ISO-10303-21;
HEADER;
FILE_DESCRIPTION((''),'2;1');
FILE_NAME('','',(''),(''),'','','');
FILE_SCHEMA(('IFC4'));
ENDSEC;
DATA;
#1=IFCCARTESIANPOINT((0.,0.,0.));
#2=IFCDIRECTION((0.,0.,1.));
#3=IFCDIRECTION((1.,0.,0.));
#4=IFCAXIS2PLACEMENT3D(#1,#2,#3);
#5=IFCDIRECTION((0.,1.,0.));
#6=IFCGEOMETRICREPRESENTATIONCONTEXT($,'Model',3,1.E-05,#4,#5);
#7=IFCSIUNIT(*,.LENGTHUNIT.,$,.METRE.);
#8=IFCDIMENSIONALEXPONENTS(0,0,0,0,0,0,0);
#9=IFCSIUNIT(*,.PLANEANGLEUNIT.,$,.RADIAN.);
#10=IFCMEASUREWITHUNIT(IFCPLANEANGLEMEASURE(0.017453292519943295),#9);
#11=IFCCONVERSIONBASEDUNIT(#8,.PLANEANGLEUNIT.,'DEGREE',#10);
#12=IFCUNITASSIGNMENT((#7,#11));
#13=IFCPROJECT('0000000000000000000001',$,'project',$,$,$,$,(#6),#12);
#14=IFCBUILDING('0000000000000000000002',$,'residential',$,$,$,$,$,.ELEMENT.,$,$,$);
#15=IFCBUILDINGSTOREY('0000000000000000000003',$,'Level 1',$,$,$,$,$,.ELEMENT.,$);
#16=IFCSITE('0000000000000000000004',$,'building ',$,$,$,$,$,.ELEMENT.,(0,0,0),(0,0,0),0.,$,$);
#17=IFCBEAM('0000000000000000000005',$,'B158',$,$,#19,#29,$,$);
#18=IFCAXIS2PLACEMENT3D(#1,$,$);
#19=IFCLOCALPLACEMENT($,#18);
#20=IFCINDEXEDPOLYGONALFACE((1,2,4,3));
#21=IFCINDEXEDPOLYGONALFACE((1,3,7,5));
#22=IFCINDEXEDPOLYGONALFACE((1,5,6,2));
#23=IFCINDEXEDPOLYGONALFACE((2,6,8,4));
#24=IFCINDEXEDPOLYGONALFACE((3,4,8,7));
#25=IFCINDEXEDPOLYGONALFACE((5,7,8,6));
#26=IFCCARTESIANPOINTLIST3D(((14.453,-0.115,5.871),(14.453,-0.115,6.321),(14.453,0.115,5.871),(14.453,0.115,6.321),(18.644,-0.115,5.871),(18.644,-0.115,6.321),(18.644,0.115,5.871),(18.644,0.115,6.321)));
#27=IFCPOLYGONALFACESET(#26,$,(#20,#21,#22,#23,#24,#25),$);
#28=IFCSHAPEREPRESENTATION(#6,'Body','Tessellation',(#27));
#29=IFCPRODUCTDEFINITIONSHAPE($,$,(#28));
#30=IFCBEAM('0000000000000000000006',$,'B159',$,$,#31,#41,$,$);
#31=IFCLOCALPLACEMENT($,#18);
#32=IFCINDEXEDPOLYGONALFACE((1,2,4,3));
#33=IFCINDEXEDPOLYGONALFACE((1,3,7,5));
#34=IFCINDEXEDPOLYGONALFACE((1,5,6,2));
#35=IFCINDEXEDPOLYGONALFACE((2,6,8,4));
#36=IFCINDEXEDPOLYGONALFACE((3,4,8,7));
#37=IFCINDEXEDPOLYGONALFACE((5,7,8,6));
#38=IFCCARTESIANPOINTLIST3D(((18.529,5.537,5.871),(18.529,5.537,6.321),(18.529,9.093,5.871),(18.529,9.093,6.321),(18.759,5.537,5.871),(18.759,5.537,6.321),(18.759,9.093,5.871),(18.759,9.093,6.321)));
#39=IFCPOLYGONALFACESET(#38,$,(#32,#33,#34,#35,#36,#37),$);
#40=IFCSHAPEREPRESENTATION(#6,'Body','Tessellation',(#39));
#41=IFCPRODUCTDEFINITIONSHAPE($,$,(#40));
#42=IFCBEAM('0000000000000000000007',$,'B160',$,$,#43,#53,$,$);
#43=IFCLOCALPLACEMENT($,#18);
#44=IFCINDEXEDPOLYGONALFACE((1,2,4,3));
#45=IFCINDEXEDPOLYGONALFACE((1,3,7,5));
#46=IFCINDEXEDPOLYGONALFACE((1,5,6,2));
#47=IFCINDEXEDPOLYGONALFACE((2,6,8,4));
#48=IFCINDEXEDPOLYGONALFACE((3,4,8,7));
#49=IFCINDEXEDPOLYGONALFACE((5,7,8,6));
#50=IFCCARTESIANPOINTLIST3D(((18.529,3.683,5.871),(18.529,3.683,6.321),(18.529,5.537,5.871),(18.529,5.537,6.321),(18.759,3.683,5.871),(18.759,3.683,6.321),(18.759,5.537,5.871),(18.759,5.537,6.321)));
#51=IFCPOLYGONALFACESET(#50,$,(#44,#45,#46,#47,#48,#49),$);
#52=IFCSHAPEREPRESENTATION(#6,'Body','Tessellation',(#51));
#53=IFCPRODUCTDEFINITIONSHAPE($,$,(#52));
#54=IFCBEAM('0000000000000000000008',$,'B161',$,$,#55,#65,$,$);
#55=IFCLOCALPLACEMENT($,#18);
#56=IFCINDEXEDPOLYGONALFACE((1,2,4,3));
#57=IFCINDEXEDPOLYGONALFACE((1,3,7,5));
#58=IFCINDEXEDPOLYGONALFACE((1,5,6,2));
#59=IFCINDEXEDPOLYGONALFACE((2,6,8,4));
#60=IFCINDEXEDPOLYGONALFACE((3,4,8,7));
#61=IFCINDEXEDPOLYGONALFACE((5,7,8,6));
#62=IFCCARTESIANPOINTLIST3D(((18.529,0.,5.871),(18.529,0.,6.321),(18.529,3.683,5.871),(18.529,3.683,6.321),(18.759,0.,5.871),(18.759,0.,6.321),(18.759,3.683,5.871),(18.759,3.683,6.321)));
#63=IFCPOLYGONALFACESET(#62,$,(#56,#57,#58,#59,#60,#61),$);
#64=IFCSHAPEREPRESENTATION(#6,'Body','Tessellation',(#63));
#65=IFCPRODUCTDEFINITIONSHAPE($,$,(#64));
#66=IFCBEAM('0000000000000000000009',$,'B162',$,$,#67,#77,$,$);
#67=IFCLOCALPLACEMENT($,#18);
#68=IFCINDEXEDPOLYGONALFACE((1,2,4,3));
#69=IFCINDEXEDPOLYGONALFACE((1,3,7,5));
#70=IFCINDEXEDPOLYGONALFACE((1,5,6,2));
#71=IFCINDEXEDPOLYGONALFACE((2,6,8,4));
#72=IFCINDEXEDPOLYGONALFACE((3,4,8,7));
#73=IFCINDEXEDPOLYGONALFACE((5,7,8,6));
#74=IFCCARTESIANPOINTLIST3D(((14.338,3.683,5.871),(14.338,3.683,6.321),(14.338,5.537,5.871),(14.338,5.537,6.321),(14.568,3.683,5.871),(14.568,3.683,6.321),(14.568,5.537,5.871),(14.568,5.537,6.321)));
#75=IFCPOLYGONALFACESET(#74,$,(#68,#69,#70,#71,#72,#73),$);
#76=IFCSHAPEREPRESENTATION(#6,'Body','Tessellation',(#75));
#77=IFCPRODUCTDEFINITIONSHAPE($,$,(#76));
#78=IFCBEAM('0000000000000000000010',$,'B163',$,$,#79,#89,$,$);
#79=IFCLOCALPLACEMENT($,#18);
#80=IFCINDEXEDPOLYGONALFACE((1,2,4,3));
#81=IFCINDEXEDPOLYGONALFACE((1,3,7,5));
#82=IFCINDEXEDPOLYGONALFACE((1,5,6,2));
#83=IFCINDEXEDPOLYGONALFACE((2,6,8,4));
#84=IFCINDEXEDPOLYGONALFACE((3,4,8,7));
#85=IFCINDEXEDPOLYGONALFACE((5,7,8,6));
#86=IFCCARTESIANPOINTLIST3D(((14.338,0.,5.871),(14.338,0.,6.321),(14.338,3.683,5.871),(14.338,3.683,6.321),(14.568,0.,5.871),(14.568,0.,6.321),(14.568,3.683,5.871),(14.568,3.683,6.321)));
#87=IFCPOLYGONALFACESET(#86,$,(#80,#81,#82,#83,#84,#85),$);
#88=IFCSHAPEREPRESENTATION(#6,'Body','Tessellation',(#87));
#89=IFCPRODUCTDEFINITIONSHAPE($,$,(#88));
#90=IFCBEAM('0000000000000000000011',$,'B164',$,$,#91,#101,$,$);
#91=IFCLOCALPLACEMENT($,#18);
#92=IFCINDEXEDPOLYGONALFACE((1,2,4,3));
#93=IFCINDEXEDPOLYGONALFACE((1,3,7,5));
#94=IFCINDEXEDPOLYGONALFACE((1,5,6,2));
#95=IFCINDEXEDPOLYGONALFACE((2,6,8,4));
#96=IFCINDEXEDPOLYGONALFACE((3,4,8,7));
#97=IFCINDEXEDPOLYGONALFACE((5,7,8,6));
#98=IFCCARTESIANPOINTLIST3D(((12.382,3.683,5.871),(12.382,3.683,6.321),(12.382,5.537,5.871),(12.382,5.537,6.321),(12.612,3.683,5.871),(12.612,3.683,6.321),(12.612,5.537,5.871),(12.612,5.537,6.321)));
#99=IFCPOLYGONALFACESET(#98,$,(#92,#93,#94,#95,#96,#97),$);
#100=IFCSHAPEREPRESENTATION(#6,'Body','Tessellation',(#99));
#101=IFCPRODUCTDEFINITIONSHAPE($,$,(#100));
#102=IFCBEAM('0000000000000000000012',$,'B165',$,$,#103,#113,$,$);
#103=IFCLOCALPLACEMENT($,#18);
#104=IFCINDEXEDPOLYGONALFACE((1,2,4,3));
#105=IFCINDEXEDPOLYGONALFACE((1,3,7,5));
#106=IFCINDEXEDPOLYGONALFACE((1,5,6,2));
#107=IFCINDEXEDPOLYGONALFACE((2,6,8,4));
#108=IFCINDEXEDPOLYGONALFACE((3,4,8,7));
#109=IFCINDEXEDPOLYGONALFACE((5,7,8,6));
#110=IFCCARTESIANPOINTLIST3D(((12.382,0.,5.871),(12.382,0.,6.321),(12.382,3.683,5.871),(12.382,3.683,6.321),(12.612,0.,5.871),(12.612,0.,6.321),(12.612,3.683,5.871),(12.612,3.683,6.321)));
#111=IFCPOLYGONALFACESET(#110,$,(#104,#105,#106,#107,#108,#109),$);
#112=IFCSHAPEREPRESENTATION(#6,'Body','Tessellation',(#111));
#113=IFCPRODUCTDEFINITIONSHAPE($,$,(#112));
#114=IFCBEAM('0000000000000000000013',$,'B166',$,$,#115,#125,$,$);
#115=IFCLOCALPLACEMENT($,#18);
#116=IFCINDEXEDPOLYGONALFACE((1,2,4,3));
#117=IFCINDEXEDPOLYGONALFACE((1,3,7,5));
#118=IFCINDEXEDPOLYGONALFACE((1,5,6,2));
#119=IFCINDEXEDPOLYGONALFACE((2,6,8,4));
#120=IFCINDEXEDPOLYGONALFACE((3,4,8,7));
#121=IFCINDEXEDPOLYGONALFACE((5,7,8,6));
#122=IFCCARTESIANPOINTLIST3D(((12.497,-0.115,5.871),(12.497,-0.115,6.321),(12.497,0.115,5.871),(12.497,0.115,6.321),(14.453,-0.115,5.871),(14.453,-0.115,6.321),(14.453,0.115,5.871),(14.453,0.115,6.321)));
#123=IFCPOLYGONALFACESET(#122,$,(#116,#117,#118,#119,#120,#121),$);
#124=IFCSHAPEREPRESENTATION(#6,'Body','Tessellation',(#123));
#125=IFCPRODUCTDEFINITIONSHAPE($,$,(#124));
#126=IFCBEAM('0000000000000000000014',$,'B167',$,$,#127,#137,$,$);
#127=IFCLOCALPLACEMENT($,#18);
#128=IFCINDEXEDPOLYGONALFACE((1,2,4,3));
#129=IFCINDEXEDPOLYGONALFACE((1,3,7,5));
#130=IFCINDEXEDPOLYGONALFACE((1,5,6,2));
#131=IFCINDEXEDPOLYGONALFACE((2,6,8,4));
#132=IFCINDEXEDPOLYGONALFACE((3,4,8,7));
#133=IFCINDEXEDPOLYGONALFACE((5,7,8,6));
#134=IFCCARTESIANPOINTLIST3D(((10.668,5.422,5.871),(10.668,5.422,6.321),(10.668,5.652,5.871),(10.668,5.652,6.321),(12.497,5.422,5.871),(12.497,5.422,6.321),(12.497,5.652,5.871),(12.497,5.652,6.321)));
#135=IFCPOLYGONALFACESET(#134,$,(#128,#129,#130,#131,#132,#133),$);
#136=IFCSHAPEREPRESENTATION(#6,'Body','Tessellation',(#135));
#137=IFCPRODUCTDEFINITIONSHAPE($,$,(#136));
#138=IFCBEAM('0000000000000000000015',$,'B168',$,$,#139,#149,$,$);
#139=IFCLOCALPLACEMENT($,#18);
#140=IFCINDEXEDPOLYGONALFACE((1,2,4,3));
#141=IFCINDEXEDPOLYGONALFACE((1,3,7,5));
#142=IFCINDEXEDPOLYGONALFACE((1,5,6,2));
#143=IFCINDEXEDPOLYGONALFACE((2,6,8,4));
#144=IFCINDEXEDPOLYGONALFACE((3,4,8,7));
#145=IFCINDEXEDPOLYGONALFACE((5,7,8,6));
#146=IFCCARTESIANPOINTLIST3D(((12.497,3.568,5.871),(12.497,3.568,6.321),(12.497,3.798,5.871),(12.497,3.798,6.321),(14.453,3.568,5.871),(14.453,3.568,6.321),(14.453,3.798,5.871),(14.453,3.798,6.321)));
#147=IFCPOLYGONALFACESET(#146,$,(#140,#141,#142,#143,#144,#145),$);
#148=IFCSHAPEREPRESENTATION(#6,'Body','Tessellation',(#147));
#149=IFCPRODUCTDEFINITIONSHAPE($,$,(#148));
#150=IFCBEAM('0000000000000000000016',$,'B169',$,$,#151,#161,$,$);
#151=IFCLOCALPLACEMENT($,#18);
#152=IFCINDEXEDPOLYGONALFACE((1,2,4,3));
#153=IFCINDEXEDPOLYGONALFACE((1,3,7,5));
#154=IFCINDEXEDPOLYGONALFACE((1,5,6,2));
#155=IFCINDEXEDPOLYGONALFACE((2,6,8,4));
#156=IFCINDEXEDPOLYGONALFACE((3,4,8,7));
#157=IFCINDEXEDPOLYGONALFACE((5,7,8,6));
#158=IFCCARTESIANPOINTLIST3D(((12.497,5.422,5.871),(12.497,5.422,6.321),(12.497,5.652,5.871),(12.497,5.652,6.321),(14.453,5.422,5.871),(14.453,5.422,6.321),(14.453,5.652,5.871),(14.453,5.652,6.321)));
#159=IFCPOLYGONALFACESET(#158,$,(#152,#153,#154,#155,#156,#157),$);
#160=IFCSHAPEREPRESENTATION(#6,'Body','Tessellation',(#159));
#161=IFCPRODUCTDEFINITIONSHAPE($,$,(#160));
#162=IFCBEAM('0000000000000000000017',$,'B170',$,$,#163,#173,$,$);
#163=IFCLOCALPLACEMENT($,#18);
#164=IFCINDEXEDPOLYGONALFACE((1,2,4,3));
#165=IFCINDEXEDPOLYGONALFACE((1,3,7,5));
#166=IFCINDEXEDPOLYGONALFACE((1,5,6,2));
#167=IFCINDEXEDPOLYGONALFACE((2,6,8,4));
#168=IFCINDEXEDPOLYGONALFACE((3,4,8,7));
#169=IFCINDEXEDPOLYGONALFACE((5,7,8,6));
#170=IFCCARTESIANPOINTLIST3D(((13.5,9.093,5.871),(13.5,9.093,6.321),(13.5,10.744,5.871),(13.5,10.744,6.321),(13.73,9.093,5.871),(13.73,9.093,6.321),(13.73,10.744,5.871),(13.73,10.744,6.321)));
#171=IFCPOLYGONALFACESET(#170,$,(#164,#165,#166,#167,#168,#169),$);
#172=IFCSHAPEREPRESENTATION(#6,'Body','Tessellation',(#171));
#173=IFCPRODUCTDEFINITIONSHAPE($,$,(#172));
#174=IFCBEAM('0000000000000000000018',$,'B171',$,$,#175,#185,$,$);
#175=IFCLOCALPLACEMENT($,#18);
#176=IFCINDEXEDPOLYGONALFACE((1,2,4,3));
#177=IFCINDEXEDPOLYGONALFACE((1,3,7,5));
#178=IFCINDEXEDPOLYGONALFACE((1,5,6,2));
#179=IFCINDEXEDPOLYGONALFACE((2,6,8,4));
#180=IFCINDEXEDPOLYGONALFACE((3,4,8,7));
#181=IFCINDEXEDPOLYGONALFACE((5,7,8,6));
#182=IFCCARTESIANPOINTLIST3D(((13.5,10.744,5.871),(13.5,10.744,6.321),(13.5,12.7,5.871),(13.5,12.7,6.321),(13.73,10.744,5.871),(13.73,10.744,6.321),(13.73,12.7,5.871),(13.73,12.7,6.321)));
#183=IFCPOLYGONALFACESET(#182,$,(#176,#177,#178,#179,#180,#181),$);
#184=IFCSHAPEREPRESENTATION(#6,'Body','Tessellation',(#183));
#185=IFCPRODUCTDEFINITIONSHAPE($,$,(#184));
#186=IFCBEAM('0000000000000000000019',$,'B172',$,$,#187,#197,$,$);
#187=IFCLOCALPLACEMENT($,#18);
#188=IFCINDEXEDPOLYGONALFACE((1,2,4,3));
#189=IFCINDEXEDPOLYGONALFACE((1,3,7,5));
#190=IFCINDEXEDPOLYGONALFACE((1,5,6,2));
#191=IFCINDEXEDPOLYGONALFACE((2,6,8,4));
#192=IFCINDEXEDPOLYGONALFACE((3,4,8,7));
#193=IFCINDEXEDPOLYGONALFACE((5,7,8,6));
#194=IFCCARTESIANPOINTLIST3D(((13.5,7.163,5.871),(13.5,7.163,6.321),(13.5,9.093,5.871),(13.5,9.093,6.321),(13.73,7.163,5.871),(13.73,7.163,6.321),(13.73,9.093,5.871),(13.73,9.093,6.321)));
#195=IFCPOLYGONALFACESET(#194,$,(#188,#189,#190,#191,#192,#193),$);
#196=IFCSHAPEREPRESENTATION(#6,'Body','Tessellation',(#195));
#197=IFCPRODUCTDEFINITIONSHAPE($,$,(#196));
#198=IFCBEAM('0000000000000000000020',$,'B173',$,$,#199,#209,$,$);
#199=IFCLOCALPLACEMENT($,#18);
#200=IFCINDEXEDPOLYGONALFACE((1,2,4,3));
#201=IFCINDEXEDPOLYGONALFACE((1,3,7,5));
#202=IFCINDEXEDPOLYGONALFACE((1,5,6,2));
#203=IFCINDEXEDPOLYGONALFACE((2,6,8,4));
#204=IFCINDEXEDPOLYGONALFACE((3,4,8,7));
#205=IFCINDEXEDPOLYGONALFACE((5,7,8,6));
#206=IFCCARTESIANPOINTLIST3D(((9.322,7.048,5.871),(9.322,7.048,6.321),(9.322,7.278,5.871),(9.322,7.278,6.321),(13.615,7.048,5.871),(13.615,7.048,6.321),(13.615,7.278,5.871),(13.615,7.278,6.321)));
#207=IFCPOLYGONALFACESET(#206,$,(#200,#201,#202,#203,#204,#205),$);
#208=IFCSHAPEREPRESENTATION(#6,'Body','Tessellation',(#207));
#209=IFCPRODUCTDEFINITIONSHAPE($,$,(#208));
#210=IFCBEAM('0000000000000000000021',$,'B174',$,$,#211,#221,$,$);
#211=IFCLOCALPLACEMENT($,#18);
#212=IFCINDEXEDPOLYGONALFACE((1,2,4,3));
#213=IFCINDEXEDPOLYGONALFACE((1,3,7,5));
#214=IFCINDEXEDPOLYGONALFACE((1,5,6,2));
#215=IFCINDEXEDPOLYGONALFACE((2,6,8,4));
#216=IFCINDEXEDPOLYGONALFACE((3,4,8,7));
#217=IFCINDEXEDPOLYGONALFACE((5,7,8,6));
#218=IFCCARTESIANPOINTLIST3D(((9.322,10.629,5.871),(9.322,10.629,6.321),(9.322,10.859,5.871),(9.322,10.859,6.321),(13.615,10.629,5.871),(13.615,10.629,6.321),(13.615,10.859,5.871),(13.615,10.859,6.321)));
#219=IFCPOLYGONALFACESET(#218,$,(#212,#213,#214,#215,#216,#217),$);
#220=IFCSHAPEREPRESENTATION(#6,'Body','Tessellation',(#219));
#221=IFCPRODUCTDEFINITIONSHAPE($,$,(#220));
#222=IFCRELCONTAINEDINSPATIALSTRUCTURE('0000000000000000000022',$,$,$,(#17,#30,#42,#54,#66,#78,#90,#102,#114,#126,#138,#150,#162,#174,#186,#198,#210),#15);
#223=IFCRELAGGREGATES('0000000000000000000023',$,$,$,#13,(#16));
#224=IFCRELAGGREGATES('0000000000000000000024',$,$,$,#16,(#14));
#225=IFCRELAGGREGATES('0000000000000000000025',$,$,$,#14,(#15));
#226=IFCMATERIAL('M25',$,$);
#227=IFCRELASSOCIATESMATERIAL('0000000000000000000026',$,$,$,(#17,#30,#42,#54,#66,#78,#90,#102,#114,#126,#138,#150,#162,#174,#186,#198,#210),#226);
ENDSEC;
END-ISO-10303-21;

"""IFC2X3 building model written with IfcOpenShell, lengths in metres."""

from ifc_helpers import new_model, entity, si_unit, converted_unit, direction, frame, frame_2d, origin_with_axes, place, context, project, spatial, rectangle, extrude, material, element, save


model = new_model("IFC2X3")

# Units and contexts
model_context = context("Model", 3, precision=1e-05, world=origin_with_axes(), true_north=direction((0.0, 1.0, 0.0)))
ifc_project = project(units=[si_unit("LENGTHUNIT", "METRE"), converted_unit("PLANEANGLEUNIT", "DEGREE", entity("IfcPlaneAngleMeasure", 0.017453292519943295), si_unit("PLANEANGLEUNIT", "RADIAN"), dimensions=[0, 0, 0, 0, 0, 0, 0])], contexts=[model_context])

# Site, building, storey
site = spatial("IfcSite", under=ifc_project, Name="building ", CompositionType="ELEMENT", RefLatitude=(0, 0, 0), RefLongitude=(0, 0, 0), RefElevation=0.0)
building = spatial("IfcBuilding", under=site, Name="residential", CompositionType="ELEMENT")
storey = spatial("IfcBuildingStorey", under=building, Name="Level 1", CompositionType="ELEMENT")

# Beams
ifc_material = material(Name="M25")
placement = place(None, origin_with_axes())
element("IfcBeam", 1, at=placement, inside=storey, material=ifc_material, Name="B158", context=model_context, shape_type="SweptSolid", body=[
    extrude(rectangle(XDim=0.23, YDim=0.45, at=frame_2d((0.0, 0.0), x_axis=(0.0, 1.0, 0.0))), frame((18.644, 0.0, 6.096), z_axis=(-1.0, 0.0, 0.0), x_axis=(0.0, 0.0, -1.0)), (0.0, 0.0, 1.0), 4.191),
])
element("IfcBeam", 2, at=placement, inside=storey, material=ifc_material, Name="B159", context=model_context, shape_type="SweptSolid", body=[
    extrude(rectangle(XDim=0.23, YDim=0.45, at=frame_2d((0.0, 0.0), x_axis=(0.0, 1.0, 0.0))), frame((18.644, 9.093, 6.096), z_axis=(0.0, -1.0, 0.0), x_axis=(0.0, 0.0, -1.0)), (0.0, 0.0, 1.0), 3.556),
])
element("IfcBeam", 3, at=placement, inside=storey, material=ifc_material, Name="B160", context=model_context, shape_type="SweptSolid", body=[
    extrude(rectangle(XDim=0.23, YDim=0.45, at=frame_2d((0.0, 0.0), x_axis=(0.0, 1.0, 0.0))), frame((18.644, 3.683, 6.096), z_axis=(0.0, 1.0, 0.0), x_axis=(0.0, 0.0, -1.0)), (0.0, 0.0, 1.0), 1.854),
])
element("IfcBeam", 4, at=placement, inside=storey, material=ifc_material, Name="B161", context=model_context, shape_type="SweptSolid", body=[
    extrude(rectangle(XDim=0.23, YDim=0.45, at=frame_2d((0.0, 0.0), x_axis=(0.0, 1.0, 0.0))), frame((18.644, 0.0, 6.096), z_axis=(0.0, 1.0, 0.0), x_axis=(0.0, 0.0, -1.0)), (0.0, 0.0, 1.0), 3.683),
])
element("IfcBeam", 5, at=placement, inside=storey, material=ifc_material, Name="B162", context=model_context, shape_type="SweptSolid", body=[
    extrude(rectangle(XDim=0.23, YDim=0.45, at=frame_2d((0.0, 0.0), x_axis=(0.0, 1.0, 0.0))), frame((14.453, 3.683, 6.096), z_axis=(0.0, 1.0, 0.0), x_axis=(0.0, 0.0, -1.0)), (0.0, 0.0, 1.0), 1.854),
])
element("IfcBeam", 6, at=placement, inside=storey, material=ifc_material, Name="B163", context=model_context, shape_type="SweptSolid", body=[
    extrude(rectangle(XDim=0.23, YDim=0.45, at=frame_2d((0.0, 0.0), x_axis=(0.0, 1.0, 0.0))), frame((14.453, 0.0, 6.096), z_axis=(0.0, 1.0, 0.0), x_axis=(0.0, 0.0, -1.0)), (0.0, 0.0, 1.0), 3.683),
])
element("IfcBeam", 7, at=placement, inside=storey, material=ifc_material, Name="B164", context=model_context, shape_type="SweptSolid", body=[
    extrude(rectangle(XDim=0.23, YDim=0.45, at=frame_2d((0.0, 0.0), x_axis=(0.0, 1.0, 0.0))), frame((12.497, 3.683, 6.096), z_axis=(0.0, 1.0, 0.0), x_axis=(0.0, 0.0, -1.0)), (0.0, 0.0, 1.0), 1.854),
])
element("IfcBeam", 8, at=placement, inside=storey, material=ifc_material, Name="B165", context=model_context, shape_type="SweptSolid", body=[
    extrude(rectangle(XDim=0.23, YDim=0.45, at=frame_2d((0.0, 0.0), x_axis=(0.0, 1.0, 0.0))), frame((12.497, 0.0, 6.096), z_axis=(0.0, 1.0, 0.0), x_axis=(0.0, 0.0, -1.0)), (0.0, 0.0, 1.0), 3.683),
])
element("IfcBeam", 9, at=placement, inside=storey, material=ifc_material, Name="B166", context=model_context, shape_type="SweptSolid", body=[
    extrude(rectangle(XDim=0.23, YDim=0.45, at=frame_2d((0.0, 0.0), x_axis=(0.0, 1.0, 0.0))), frame((12.497, 0.0, 6.096), z_axis=(1.0, 0.0, 0.0), x_axis=(0.0, 0.0, -1.0)), (0.0, 0.0, 1.0), 1.956),
])
element("IfcBeam", 10, at=placement, inside=storey, material=ifc_material, Name="B167", context=model_context, shape_type="SweptSolid", body=[
    extrude(rectangle(XDim=0.23, YDim=0.45, at=frame_2d((0.0, 0.0), x_axis=(0.0, 1.0, 0.0))), frame((10.668, 5.537, 6.096), z_axis=(1.0, 0.0, 0.0), x_axis=(0.0, 0.0, -1.0)), (0.0, 0.0, 1.0), 1.829),
])
element("IfcBeam", 11, at=placement, inside=storey, material=ifc_material, Name="B168", context=model_context, shape_type="SweptSolid", body=[
    extrude(rectangle(XDim=0.23, YDim=0.45, at=frame_2d((0.0, 0.0), x_axis=(0.0, 1.0, 0.0))), frame((12.497, 3.683, 6.096), z_axis=(1.0, 0.0, 0.0), x_axis=(0.0, 0.0, -1.0)), (0.0, 0.0, 1.0), 1.956),
])
element("IfcBeam", 12, at=placement, inside=storey, material=ifc_material, Name="B169", context=model_context, shape_type="SweptSolid", body=[
    extrude(rectangle(XDim=0.23, YDim=0.45, at=frame_2d((0.0, 0.0), x_axis=(0.0, 1.0, 0.0))), frame((12.497, 5.537, 6.096), z_axis=(1.0, 0.0, 0.0), x_axis=(0.0, 0.0, -1.0)), (0.0, 0.0, 1.0), 1.956),
])
element("IfcBeam", 13, at=placement, inside=storey, material=ifc_material, Name="B170", context=model_context, shape_type="SweptSolid", body=[
    extrude(rectangle(XDim=0.23, YDim=0.45, at=frame_2d((0.0, 0.0), x_axis=(0.0, 1.0, 0.0))), frame((13.615, 9.093, 6.096), z_axis=(0.0, 1.0, 0.0), x_axis=(0.0, 0.0, -1.0)), (0.0, 0.0, 1.0), 1.651),
])
element("IfcBeam", 14, at=placement, inside=storey, material=ifc_material, Name="B171", context=model_context, shape_type="SweptSolid", body=[
    extrude(rectangle(XDim=0.23, YDim=0.45, at=frame_2d((0.0, 0.0), x_axis=(0.0, 1.0, 0.0))), frame((13.615, 10.744, 6.096), z_axis=(0.0, 1.0, 0.0), x_axis=(0.0, 0.0, -1.0)), (0.0, 0.0, 1.0), 1.956),
])
element("IfcBeam", 15, at=placement, inside=storey, material=ifc_material, Name="B172", context=model_context, shape_type="SweptSolid", body=[
    extrude(rectangle(XDim=0.23, YDim=0.45, at=frame_2d((0.0, 0.0), x_axis=(0.0, 1.0, 0.0))), frame((13.615, 7.163, 6.096), z_axis=(0.0, 1.0, 0.0), x_axis=(0.0, 0.0, -1.0)), (0.0, 0.0, 1.0), 1.93),
])
element("IfcBeam", 16, at=placement, inside=storey, material=ifc_material, Name="B173", context=model_context, shape_type="SweptSolid", body=[
    extrude(rectangle(XDim=0.23, YDim=0.45, at=frame_2d((0.0, 0.0), x_axis=(0.0, 1.0, 0.0))), frame((9.322, 7.163, 6.096), z_axis=(1.0, 0.0, 0.0), x_axis=(0.0, 0.0, -1.0)), (0.0, 0.0, 1.0), 4.293),
])
element("IfcBeam", 17, at=placement, inside=storey, material=ifc_material, Name="B174", context=model_context, shape_type="SweptSolid", body=[
    extrude(rectangle(XDim=0.23, YDim=0.45, at=frame_2d((0.0, 0.0), x_axis=(0.0, 1.0, 0.0))), frame((9.322, 10.744, 6.096), z_axis=(1.0, 0.0, 0.0), x_axis=(0.0, 0.0, -1.0)), (0.0, 0.0, 1.0), 4.293),
])

save(model, "model.ifc")
